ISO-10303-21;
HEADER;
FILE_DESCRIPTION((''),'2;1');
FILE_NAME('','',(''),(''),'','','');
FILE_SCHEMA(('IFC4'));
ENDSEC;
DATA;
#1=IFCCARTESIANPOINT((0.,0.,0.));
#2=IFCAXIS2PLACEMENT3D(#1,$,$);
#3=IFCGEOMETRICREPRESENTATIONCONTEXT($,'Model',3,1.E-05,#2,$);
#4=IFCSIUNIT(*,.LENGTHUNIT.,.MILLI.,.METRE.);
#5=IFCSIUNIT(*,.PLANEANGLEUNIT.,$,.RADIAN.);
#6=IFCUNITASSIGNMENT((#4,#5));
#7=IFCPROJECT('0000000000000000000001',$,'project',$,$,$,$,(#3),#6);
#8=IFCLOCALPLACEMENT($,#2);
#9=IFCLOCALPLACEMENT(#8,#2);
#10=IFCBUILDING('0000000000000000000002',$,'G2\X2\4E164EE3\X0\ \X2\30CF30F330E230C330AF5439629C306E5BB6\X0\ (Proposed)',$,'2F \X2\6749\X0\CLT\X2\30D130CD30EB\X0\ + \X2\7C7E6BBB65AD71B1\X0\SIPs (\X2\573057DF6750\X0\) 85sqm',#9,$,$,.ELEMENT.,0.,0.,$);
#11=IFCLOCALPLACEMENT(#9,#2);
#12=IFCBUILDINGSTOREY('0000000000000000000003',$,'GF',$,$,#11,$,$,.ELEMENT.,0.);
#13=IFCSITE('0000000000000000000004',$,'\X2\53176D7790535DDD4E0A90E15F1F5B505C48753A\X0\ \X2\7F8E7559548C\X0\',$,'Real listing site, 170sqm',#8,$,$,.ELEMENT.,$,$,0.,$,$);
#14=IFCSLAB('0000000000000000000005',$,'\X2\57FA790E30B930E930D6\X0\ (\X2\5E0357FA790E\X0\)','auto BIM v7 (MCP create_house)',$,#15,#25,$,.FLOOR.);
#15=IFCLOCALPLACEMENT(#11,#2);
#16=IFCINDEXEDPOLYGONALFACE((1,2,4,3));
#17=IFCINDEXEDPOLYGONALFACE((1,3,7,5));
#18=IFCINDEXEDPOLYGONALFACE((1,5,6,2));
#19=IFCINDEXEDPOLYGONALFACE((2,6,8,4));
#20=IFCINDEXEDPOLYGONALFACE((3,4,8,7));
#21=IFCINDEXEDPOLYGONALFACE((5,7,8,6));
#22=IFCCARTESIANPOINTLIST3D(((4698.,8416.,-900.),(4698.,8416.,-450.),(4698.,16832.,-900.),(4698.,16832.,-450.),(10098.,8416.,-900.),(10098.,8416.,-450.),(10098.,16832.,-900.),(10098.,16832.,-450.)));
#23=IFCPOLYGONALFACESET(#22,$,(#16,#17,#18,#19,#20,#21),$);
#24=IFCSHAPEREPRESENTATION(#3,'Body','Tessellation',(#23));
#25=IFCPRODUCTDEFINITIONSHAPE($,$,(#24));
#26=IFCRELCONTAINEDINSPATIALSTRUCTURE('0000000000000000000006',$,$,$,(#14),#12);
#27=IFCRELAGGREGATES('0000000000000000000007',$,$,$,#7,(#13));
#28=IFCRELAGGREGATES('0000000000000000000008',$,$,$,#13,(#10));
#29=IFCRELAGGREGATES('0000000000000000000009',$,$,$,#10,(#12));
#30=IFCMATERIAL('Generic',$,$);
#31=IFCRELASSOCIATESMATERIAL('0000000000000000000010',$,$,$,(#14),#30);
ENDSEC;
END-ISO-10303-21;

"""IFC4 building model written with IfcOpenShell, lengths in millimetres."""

from ifc_helpers import new_model, si_unit, frame, frame_2d, origin, place, context, project, spatial, rectangle, extrude, material, element, save


model = new_model("IFC4")

# Units and contexts
model_context = context("Model", 3, precision=1e-05, world=origin())
ifc_project = project(units=[si_unit("LENGTHUNIT", "METRE", prefix="MILLI"), si_unit("PLANEANGLEUNIT", "RADIAN")], contexts=[model_context])

# Site, building, storey
site_placement = place(None, origin())
site = spatial("IfcSite", under=ifc_project, at=site_placement, Name="北海道川上郡弟子屈町 美留和", ObjectType="Real listing site, 170sqm", CompositionType="ELEMENT", RefElevation=0.0)
building_placement = place(site_placement, origin())
building = spatial("IfcBuilding", under=site, at=building_placement, Name="G2世代 ハンモック吹抜の家 (Proposed)", ObjectType="2F 杉CLTパネル + 籾殻断熱SIPs (地域材) 85sqm", CompositionType="ELEMENT", ElevationOfRefHeight=0.0, ElevationOfTerrain=0.0)
storey_placement = place(building_placement, origin())
storey = spatial("IfcBuildingStorey", under=building, at=storey_placement, Name="GF", CompositionType="ELEMENT", Elevation=0.0)

# Slab
ifc_material = material(Name="Generic")
slab_1_placement = place(storey_placement, frame((2349.0, 4208.0, -450.0)))
element("IfcSlab", 1, at=slab_1_placement, inside=storey, material=ifc_material, Name="基礎スラブ (布基礎)", Description="auto BIM v7 (MCP create_house)", PredefinedType="FLOOR", context=model_context, shape_type="SweptSolid", body=[
    extrude(rectangle(XDim=5400.0, YDim=8416.0, at=frame_2d((2700.0, 4208.0))), frame((2349.0, 4208.0, -450.0)), (0.0, 0.0, 1.0), 450.0),
])

save(model, "model.ifc")
